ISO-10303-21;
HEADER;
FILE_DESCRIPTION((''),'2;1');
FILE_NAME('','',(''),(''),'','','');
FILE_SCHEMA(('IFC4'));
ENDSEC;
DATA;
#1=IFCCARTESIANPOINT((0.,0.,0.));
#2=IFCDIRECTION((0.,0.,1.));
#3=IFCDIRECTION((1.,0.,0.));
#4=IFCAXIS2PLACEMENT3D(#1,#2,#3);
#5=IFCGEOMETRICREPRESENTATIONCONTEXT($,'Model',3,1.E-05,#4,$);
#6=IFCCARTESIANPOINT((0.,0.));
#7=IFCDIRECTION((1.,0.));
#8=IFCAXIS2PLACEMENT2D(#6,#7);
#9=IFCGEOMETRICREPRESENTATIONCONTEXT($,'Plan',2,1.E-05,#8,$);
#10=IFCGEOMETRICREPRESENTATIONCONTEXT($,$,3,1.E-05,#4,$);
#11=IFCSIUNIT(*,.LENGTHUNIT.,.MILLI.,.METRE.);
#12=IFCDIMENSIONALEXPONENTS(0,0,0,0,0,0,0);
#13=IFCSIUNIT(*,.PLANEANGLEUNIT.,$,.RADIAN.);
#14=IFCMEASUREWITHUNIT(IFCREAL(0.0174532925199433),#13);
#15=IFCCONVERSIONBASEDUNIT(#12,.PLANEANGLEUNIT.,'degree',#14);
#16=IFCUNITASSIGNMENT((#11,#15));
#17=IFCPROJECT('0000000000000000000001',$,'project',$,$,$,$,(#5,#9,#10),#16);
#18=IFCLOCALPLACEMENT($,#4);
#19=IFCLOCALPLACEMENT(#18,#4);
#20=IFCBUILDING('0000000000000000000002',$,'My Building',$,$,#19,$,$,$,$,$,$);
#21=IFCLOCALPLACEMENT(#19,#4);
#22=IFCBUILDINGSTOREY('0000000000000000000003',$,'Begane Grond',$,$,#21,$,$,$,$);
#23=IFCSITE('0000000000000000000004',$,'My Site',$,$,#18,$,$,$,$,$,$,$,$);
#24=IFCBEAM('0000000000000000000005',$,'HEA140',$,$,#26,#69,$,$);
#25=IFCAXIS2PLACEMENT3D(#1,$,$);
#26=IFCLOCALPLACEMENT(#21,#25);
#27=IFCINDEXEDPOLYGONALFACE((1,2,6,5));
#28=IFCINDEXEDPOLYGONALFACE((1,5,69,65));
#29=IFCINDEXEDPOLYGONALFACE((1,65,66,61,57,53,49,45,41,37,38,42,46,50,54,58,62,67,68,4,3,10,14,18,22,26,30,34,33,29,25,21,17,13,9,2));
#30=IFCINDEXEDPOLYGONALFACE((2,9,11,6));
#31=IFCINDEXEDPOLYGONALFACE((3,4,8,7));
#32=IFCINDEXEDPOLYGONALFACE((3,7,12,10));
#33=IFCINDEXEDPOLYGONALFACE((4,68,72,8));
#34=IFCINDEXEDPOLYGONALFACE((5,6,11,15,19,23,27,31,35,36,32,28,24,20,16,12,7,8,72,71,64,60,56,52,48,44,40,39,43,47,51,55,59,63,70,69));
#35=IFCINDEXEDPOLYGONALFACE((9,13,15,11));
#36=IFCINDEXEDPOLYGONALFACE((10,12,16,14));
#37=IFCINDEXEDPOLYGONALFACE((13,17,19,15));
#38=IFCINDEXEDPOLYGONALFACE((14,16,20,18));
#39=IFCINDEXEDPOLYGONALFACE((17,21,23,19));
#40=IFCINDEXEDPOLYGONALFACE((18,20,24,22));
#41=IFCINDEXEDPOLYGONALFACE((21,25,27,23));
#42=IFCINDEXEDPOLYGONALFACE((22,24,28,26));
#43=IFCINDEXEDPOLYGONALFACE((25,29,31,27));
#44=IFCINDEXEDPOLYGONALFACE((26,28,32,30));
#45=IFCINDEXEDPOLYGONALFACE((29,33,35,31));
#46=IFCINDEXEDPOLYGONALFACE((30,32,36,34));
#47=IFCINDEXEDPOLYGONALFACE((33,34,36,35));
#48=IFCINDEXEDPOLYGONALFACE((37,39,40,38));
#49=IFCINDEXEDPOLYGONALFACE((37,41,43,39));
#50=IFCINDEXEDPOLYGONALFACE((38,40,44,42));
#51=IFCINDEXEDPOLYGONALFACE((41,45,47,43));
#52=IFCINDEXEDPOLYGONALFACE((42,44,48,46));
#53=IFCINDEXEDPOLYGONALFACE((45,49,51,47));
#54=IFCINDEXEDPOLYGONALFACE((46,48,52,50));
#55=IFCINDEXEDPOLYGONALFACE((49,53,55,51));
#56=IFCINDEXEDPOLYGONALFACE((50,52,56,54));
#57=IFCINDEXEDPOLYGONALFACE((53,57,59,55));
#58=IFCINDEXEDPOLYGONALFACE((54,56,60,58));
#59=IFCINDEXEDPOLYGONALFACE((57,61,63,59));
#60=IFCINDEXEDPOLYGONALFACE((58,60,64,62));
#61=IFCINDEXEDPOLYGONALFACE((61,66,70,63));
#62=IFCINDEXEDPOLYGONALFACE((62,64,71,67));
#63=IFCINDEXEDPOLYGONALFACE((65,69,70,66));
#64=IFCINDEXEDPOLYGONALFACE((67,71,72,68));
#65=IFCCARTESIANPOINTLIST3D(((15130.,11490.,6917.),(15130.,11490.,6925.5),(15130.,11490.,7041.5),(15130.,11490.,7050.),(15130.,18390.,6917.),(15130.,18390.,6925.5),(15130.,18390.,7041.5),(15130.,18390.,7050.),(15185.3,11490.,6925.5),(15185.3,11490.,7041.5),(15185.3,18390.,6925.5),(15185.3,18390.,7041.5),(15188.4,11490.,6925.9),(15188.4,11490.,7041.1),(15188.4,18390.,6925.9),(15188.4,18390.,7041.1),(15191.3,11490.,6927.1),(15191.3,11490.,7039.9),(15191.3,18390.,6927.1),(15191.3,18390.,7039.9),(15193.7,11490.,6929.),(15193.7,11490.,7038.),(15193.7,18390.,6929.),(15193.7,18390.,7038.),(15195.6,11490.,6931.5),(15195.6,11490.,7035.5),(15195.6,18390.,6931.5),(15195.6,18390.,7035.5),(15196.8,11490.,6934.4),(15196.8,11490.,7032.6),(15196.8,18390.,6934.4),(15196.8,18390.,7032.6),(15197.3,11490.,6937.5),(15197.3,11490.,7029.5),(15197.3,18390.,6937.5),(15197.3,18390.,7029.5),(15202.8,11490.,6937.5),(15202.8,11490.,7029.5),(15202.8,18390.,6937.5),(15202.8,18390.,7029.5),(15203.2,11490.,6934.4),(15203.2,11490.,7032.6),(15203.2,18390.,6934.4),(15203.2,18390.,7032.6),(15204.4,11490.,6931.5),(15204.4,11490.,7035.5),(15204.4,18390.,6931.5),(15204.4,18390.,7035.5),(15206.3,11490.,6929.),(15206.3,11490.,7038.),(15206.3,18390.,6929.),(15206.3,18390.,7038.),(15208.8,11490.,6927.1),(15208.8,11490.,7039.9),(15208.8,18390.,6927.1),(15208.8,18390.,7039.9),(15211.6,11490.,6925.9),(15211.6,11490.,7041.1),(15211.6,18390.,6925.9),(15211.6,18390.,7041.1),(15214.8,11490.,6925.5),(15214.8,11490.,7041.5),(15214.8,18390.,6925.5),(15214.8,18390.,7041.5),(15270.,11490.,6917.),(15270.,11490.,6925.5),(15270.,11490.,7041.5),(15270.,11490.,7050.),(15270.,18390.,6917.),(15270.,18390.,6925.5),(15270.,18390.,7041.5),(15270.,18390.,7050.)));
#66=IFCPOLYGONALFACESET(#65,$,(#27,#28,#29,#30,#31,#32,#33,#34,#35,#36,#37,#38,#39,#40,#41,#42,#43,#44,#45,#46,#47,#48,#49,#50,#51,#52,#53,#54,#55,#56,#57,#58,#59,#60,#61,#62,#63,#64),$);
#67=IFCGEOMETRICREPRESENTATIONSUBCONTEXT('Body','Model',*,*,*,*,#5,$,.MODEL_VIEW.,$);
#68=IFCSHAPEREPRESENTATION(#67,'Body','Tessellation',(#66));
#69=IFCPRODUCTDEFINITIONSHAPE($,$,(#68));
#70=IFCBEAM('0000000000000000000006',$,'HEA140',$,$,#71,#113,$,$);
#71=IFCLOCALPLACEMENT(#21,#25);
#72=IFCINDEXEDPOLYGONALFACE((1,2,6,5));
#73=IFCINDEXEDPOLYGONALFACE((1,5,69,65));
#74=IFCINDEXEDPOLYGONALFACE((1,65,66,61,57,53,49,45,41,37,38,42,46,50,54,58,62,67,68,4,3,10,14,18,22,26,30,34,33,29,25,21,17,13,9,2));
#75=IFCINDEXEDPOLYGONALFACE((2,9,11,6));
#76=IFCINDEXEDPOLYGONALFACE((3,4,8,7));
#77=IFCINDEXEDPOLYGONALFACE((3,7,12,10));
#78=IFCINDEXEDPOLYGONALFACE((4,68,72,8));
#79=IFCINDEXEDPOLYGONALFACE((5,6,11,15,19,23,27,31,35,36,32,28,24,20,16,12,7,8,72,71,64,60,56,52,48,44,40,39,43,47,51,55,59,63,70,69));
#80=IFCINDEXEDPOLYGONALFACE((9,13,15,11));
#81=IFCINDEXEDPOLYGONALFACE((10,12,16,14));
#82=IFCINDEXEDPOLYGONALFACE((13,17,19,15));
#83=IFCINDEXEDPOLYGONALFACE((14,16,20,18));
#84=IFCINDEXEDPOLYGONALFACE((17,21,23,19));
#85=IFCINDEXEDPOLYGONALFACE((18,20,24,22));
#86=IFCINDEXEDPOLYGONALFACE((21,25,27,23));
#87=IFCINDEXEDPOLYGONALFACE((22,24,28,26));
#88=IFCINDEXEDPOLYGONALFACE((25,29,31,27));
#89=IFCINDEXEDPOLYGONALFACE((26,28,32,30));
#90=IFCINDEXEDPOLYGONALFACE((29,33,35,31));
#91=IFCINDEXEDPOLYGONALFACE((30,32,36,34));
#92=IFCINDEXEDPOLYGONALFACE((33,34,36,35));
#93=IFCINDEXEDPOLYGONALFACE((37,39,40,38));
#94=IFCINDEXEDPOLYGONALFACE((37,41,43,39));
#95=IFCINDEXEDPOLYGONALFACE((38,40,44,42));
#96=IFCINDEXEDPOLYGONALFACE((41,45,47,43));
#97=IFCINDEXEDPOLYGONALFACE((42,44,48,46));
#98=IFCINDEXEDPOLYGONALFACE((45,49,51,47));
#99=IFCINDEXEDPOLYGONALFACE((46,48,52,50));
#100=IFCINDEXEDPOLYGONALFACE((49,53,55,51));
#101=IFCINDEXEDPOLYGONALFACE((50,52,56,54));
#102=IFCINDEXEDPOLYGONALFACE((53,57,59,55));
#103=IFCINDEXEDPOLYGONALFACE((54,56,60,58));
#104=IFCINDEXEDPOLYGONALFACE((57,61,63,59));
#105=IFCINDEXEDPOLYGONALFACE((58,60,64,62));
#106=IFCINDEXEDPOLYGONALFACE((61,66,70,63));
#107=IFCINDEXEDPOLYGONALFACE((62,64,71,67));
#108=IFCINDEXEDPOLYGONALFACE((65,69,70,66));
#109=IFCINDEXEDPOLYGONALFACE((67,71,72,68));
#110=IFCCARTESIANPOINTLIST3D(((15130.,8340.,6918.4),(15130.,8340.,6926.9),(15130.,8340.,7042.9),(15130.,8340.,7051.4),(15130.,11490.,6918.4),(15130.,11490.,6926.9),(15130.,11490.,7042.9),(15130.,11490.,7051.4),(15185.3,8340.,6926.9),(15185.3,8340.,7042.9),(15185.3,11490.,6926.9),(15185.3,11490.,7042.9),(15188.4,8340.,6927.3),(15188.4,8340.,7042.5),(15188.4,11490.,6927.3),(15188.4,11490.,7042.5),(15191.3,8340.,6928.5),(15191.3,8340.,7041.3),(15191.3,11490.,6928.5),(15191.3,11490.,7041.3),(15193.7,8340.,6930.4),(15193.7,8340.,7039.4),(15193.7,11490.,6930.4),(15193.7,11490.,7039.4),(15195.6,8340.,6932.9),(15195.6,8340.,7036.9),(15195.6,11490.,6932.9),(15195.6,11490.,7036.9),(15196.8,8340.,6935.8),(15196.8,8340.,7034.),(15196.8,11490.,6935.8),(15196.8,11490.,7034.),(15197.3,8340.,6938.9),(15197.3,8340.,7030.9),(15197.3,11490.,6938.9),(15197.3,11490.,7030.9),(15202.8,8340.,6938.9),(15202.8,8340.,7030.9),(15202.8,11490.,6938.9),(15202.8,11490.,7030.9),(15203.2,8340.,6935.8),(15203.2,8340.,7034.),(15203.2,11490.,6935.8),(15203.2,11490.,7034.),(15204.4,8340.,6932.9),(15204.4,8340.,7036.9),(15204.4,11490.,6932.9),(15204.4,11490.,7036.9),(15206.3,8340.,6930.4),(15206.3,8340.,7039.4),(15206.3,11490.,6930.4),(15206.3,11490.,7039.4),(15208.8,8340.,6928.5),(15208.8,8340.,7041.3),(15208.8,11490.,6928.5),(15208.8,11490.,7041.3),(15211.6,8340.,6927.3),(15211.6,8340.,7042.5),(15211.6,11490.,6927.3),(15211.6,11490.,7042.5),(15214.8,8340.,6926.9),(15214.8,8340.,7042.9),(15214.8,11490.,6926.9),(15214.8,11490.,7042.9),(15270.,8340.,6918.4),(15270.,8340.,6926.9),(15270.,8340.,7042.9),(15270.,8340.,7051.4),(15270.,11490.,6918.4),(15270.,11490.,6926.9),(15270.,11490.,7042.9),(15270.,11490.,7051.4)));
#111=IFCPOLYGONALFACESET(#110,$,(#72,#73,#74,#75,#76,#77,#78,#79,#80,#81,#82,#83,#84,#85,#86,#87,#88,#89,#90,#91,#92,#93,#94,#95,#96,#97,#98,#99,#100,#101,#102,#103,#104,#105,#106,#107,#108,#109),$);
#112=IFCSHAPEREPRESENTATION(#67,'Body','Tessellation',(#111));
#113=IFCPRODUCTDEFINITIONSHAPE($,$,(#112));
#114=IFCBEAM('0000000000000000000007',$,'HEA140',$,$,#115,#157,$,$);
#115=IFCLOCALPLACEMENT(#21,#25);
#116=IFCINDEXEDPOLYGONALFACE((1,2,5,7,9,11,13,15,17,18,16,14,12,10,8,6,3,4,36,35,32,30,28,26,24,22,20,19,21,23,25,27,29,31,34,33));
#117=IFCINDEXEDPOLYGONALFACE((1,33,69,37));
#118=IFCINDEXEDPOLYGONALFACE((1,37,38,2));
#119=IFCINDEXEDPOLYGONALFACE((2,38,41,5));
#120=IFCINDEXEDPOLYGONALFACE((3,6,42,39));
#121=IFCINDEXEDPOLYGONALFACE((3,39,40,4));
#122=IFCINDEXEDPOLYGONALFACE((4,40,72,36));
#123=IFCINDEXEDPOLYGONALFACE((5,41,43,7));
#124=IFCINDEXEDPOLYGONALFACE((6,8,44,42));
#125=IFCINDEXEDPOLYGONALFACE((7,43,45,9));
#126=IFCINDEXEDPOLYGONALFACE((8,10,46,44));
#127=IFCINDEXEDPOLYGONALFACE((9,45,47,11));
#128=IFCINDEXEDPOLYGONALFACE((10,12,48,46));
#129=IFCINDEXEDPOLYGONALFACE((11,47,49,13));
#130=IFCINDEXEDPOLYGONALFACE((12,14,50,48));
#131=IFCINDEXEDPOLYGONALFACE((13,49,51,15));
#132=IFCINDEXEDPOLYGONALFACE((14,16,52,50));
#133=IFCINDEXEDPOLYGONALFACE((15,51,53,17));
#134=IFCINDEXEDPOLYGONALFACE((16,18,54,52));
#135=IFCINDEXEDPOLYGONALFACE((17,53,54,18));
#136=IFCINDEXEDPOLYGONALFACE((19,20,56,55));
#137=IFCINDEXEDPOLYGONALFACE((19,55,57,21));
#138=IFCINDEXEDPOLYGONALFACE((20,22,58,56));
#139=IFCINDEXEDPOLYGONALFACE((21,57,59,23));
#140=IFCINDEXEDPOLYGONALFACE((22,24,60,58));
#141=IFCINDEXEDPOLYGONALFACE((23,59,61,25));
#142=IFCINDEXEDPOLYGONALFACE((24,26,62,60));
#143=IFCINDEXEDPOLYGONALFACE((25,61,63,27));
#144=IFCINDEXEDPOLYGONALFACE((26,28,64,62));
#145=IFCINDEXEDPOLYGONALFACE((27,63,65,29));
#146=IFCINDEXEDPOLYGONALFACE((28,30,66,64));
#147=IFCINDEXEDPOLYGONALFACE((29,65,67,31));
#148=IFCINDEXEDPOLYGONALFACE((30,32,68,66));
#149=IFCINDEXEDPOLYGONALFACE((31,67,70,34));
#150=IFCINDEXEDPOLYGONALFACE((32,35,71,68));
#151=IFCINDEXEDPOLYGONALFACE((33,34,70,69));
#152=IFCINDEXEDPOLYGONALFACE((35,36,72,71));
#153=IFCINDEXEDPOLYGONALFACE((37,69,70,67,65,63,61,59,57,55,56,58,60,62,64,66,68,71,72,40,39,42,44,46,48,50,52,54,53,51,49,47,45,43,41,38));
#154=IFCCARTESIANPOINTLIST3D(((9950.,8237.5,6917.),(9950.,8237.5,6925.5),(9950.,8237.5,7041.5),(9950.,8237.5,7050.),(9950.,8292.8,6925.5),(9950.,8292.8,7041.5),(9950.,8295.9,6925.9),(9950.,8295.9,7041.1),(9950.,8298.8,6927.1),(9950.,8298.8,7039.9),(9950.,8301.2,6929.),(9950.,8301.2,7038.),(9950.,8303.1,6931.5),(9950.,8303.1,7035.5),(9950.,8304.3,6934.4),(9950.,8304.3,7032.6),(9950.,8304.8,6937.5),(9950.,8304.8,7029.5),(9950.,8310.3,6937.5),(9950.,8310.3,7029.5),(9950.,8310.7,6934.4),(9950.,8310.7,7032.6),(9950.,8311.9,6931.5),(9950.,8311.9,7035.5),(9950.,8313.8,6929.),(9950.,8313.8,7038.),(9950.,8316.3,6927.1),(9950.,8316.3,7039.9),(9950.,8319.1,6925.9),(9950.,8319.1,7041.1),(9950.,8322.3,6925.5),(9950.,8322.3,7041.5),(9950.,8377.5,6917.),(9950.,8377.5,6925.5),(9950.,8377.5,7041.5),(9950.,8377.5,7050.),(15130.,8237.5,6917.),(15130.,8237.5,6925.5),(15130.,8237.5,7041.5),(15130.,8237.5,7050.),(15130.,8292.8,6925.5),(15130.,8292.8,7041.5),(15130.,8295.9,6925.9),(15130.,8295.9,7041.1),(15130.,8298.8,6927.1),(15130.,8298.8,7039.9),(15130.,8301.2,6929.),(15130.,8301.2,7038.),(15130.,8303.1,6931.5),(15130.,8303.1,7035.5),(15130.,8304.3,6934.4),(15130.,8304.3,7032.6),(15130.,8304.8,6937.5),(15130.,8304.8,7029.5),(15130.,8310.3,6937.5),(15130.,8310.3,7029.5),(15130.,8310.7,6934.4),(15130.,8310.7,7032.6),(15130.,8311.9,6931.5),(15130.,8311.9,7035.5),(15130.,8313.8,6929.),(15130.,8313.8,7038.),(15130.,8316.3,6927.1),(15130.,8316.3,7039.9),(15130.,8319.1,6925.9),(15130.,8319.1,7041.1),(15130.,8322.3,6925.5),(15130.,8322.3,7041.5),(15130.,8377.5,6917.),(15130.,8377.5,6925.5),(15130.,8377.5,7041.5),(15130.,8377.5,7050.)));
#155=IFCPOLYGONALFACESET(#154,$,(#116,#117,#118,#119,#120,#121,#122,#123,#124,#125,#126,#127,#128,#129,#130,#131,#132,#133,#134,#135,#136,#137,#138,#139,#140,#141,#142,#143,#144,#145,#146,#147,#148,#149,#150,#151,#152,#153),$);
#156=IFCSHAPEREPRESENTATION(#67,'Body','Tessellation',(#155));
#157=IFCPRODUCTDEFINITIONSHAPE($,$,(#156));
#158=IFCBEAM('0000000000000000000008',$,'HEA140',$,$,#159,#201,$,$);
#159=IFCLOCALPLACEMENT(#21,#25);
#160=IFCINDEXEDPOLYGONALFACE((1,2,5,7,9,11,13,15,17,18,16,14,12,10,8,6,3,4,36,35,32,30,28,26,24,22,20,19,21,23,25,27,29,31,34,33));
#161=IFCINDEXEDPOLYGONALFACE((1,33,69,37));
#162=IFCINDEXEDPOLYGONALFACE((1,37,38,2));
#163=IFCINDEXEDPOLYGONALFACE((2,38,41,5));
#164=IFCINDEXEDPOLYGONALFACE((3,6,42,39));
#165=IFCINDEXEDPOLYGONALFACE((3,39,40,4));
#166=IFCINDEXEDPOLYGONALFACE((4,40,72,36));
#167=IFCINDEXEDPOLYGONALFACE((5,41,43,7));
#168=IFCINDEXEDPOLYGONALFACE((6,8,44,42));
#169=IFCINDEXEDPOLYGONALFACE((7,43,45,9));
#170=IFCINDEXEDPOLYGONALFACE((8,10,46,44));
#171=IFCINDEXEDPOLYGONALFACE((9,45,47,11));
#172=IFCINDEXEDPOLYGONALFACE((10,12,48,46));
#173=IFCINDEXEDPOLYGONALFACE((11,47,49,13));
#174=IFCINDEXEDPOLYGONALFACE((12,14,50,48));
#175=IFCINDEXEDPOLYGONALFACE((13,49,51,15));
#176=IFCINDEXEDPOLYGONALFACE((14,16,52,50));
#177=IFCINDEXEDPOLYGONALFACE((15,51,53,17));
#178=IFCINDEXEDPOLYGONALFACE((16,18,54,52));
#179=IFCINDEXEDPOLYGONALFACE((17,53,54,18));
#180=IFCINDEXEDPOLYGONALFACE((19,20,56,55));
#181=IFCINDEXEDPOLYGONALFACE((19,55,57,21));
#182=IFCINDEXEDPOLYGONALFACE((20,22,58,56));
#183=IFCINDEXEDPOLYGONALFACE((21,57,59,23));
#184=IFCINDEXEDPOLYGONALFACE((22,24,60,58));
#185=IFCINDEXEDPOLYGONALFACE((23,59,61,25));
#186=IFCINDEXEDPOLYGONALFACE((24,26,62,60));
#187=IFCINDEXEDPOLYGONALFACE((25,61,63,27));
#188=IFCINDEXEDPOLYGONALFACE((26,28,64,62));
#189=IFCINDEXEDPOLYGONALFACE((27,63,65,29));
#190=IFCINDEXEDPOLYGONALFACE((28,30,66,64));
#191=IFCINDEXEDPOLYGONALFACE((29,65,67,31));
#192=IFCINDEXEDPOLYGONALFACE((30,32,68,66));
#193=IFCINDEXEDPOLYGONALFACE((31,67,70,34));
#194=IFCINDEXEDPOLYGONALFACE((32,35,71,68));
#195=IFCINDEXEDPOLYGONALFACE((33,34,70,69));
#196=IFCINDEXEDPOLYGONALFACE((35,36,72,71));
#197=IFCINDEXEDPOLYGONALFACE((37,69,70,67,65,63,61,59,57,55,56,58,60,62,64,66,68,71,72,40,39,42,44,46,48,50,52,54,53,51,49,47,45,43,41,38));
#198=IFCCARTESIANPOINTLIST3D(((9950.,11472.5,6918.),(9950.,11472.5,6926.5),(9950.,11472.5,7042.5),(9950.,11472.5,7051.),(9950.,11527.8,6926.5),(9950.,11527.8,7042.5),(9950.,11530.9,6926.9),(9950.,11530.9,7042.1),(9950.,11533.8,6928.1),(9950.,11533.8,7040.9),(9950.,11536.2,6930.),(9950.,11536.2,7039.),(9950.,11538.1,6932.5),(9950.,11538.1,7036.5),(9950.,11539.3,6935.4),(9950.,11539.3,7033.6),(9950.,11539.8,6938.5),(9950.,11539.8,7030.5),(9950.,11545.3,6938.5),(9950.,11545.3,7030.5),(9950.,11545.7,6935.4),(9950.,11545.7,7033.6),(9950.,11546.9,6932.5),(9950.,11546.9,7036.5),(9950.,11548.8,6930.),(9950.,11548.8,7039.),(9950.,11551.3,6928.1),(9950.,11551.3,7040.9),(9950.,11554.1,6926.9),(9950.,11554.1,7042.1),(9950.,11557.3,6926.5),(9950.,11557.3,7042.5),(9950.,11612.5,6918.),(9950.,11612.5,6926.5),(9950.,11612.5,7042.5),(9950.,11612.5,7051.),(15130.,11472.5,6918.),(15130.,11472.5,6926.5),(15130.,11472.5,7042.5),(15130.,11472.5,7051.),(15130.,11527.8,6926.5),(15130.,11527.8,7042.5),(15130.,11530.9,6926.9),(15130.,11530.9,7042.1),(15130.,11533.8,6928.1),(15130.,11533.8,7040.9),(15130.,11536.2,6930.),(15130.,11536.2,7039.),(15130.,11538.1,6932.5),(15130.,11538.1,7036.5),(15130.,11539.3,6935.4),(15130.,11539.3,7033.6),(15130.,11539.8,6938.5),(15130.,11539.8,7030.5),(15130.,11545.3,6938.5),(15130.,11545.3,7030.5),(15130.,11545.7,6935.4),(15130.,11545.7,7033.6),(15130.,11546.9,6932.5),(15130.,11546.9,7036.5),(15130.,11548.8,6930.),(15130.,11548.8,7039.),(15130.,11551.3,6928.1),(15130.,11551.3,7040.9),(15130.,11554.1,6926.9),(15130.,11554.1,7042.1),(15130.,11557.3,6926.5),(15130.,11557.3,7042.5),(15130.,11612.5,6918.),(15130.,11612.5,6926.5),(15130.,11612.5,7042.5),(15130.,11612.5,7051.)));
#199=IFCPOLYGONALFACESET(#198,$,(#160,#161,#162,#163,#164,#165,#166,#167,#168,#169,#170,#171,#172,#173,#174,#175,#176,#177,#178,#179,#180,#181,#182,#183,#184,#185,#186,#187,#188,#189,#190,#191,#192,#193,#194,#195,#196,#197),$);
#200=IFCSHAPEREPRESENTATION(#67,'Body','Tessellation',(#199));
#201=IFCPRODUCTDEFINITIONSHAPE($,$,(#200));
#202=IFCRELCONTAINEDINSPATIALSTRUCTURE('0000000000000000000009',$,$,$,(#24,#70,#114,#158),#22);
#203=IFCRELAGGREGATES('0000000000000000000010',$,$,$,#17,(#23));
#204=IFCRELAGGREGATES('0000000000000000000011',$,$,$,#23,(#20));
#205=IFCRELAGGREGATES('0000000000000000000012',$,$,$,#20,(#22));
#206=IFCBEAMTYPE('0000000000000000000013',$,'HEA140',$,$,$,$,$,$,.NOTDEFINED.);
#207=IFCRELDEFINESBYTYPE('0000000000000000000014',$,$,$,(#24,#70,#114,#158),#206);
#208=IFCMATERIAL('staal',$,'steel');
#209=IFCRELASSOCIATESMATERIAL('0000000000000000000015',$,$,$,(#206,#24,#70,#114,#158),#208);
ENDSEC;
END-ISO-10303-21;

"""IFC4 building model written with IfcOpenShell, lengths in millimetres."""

from ifc_helpers import new_model, entity, si_unit, converted_unit, frame, origin_with_axes, origin_2d_with_axis, place, context, subcontext, project, spatial, i_section, extrude, material, material_profile, profile_set, profile_usage, type_object, element, save


model = new_model("IFC4")

# Units and contexts
model_context = context("Model", 3, precision=1e-05, world=origin_with_axes())
plan_context = context("Plan", 2, precision=1e-05, world=origin_2d_with_axis())
context_of_model = context(None, 3, precision=1e-05, world=origin_with_axes())
body_context = subcontext(model_context, "Body", "Model", "MODEL_VIEW")
ifc_project = project(units=[si_unit("LENGTHUNIT", "METRE", prefix="MILLI"), converted_unit("PLANEANGLEUNIT", "degree", entity("IfcReal", 0.0174532925199433), si_unit("PLANEANGLEUNIT", "RADIAN"), dimensions=[0, 0, 0, 0, 0, 0, 0])], contexts=[model_context, plan_context, context_of_model])

# Site, building, storey
site_placement = place(None, origin_with_axes())
site = spatial("IfcSite", under=ifc_project, at=site_placement, Name="My Site")
building_placement = place(site_placement, origin_with_axes())
building = spatial("IfcBuilding", under=site, at=building_placement, Name="My Building")
storey_placement = place(building_placement, origin_with_axes())
storey = spatial("IfcBuildingStorey", under=building, at=storey_placement, Name="Begane Grond")

# Shared definitions
ifc_material = material(Name="staal", Category="steel")

# Beams
ifc_material_profile_1 = material_profile(ifc_material, i_section(OverallWidth=140.0, OverallDepth=133.0, WebThickness=5.5, FlangeThickness=8.5, FilletRadius=12.0))
ifc_profile_set_1 = profile_set([ifc_material_profile_1], Name="HEA140")
beam_type_1 = type_object("IfcBeamType", Name="HEA140", PredefinedType="NOTDEFINED", material=ifc_profile_set_1)
ifc_profile_usage_1 = profile_usage(ifc_profile_set_1)
beam_1_placement = place(storey_placement, frame((15200.0, 11490.0, 6983.5), z_axis=(0.0, 1.0, 0.0), x_axis=(-1.0, 0.0, 0.0)))
element("IfcBeam", 1, at=beam_1_placement, inside=storey, type_object=beam_type_1, material=ifc_profile_usage_1, Name="HEA140", context=body_context, shape_type="SweptSolid", body=[
    extrude(i_section(OverallWidth=140.0, OverallDepth=133.0, WebThickness=5.5, FlangeThickness=8.5, FilletRadius=12.0), origin_with_axes(), (0.0, 0.0, 1.0), 6900.0),
])
ifc_profile_usage_2 = profile_usage(ifc_profile_set_1)
beam_2_placement = place(storey_placement, frame((15200.0, 8340.0, 6984.9), z_axis=(0.0, 1.0, 0.0), x_axis=(-1.0, 0.0, 0.0)))
element("IfcBeam", 2, at=beam_2_placement, inside=storey, type_object=beam_type_1, material=ifc_profile_usage_2, Name="HEA140", context=body_context, shape_type="SweptSolid", body=[
    extrude(i_section(OverallWidth=140.0, OverallDepth=133.0, WebThickness=5.5, FlangeThickness=8.5, FilletRadius=12.0), origin_with_axes(), (0.0, 0.0, 1.0), 3150.0),
])
ifc_profile_usage_3 = profile_usage(ifc_profile_set_1)
beam_3_placement = place(storey_placement, frame((15130.0, 8307.5, 6983.5), z_axis=(-1.0, 0.0, 0.0), x_axis=(0.0, -1.0, 0.0)))
element("IfcBeam", 3, at=beam_3_placement, inside=storey, type_object=beam_type_1, material=ifc_profile_usage_3, Name="HEA140", context=body_context, shape_type="SweptSolid", body=[
    extrude(i_section(OverallWidth=140.0, OverallDepth=133.0, WebThickness=5.5, FlangeThickness=8.5, FilletRadius=12.0), origin_with_axes(), (0.0, 0.0, 1.0), 5180.0),
])
ifc_profile_usage_4 = profile_usage(ifc_profile_set_1)
beam_4_placement = place(storey_placement, frame((9950.0, 11542.5, 6984.5), z_axis=(1.0, 0.0, 0.0), x_axis=(0.0, 1.0, 0.0)))
element("IfcBeam", 4, at=beam_4_placement, inside=storey, type_object=beam_type_1, material=ifc_profile_usage_4, Name="HEA140", context=body_context, shape_type="SweptSolid", body=[
    extrude(i_section(OverallWidth=140.0, OverallDepth=133.0, WebThickness=5.5, FlangeThickness=8.5, FilletRadius=12.0), origin_with_axes(), (0.0, 0.0, 1.0), 5180.0),
])

save(model, "model.ifc")
